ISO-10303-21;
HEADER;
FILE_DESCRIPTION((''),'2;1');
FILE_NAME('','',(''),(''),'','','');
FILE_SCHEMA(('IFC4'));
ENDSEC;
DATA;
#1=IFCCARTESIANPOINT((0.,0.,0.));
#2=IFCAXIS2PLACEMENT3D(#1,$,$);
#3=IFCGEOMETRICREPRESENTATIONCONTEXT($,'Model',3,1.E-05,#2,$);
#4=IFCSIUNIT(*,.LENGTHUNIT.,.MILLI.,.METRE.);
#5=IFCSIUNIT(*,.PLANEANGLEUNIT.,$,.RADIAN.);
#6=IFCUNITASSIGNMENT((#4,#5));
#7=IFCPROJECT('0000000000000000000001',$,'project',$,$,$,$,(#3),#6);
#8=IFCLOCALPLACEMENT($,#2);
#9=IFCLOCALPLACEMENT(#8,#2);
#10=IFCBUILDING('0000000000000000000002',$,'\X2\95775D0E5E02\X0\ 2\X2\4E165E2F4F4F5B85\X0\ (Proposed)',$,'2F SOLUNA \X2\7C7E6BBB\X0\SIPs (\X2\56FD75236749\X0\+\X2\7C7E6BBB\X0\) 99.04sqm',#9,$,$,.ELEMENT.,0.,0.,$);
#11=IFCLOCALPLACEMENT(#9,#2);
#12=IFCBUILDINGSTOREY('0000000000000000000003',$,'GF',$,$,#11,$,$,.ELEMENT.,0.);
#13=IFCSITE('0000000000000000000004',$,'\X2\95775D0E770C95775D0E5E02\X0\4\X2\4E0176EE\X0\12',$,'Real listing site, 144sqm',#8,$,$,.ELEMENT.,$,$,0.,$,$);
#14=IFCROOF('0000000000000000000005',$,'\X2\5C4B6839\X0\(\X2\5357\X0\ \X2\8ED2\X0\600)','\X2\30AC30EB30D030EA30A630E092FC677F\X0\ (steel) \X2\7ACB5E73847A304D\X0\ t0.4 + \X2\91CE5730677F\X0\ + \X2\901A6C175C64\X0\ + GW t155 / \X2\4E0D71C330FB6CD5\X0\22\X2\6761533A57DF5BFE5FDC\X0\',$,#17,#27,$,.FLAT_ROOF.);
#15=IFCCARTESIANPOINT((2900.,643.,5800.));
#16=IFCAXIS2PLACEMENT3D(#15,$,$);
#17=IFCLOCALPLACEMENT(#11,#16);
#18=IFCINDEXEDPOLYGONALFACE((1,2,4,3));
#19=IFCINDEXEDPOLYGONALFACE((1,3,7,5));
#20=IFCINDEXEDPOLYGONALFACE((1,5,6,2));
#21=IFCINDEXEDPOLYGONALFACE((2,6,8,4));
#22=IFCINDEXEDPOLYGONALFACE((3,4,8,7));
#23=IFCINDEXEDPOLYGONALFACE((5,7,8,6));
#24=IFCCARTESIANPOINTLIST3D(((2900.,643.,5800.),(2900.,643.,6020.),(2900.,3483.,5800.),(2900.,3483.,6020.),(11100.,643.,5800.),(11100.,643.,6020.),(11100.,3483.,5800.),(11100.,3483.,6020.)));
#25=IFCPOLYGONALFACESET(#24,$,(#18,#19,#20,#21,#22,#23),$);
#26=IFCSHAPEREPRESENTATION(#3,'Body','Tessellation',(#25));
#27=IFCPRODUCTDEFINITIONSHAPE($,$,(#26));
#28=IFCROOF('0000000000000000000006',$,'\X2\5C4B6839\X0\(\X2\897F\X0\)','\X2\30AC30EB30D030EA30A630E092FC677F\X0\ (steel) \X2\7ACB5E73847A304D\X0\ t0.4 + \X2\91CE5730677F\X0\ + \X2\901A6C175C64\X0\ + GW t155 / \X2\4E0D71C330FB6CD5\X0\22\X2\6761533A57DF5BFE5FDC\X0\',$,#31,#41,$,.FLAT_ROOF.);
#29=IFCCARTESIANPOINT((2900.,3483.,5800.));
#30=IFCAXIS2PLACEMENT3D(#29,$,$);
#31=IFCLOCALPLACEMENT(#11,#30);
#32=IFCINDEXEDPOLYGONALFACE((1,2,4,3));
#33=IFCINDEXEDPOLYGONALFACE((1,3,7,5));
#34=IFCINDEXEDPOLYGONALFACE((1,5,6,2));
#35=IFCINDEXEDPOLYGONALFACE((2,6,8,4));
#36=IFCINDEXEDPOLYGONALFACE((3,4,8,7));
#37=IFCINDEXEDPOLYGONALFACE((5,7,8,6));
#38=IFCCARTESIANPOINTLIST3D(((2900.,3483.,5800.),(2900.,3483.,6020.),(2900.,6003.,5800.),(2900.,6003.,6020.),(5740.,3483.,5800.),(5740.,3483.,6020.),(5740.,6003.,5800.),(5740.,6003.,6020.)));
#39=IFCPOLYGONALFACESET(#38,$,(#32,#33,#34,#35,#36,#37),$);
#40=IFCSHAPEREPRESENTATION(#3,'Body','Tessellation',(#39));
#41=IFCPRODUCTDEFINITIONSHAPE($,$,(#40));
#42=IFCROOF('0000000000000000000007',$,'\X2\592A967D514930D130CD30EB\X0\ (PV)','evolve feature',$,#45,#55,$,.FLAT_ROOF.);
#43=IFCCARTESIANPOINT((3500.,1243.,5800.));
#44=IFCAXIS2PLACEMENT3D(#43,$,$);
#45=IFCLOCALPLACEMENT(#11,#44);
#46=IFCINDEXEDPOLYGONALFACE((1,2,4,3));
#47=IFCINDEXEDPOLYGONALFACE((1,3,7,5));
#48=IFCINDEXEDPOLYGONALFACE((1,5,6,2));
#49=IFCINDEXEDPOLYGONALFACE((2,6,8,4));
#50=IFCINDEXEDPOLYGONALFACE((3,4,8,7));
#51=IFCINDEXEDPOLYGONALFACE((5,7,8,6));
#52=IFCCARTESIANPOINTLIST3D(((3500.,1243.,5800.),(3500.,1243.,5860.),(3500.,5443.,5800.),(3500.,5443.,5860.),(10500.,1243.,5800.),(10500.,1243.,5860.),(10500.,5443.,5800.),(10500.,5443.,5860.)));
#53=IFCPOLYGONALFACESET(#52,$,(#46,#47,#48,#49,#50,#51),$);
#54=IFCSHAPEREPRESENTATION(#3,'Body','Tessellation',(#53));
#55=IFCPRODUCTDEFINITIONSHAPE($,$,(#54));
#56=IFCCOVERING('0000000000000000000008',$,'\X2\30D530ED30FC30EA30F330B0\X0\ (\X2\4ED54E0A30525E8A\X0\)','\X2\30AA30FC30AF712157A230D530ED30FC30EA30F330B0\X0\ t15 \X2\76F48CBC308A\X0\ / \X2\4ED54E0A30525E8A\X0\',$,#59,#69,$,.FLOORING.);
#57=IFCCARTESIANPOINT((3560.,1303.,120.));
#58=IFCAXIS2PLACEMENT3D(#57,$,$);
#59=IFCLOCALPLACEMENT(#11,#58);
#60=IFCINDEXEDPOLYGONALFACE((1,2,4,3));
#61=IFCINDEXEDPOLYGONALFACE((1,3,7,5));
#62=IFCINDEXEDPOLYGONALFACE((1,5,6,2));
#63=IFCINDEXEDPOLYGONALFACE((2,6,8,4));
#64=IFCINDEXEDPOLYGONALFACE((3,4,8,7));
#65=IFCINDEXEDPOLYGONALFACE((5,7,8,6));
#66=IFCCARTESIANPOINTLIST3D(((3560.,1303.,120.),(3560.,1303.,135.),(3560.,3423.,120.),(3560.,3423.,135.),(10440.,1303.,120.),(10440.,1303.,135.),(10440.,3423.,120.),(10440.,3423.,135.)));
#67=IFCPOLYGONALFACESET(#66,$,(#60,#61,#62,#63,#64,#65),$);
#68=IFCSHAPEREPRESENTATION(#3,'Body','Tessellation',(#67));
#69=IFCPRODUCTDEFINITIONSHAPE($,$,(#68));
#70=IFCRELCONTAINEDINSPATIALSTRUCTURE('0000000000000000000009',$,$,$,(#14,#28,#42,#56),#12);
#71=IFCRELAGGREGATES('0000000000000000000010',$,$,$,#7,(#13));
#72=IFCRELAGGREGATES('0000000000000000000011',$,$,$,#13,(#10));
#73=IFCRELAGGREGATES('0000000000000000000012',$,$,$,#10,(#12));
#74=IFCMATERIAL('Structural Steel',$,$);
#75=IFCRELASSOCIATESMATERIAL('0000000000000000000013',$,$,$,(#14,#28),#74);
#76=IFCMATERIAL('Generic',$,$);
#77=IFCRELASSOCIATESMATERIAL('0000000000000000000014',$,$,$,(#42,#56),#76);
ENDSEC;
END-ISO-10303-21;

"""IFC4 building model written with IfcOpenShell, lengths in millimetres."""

from ifc_helpers import new_model, si_unit, frame, frame_2d, origin, place, context, project, spatial, rectangle, extrude, material, element, save


model = new_model("IFC4")

# Units and contexts
model_context = context("Model", 3, precision=1e-05, world=origin())
ifc_project = project(units=[si_unit("LENGTHUNIT", "METRE", prefix="MILLI"), si_unit("PLANEANGLEUNIT", "RADIAN")], contexts=[model_context])

# Site, building, storey
site_placement = place(None, origin())
site = spatial("IfcSite", under=ifc_project, at=site_placement, Name="長崎県長崎市4丁目12", ObjectType="Real listing site, 144sqm", CompositionType="ELEMENT", RefElevation=0.0)
building_placement = place(site_placement, origin())
building = spatial("IfcBuilding", under=site, at=building_placement, Name="長崎市 2世帯住宅 (Proposed)", ObjectType="2F SOLUNA 籾殻SIPs (国産杉+籾殻) 99.04sqm", CompositionType="ELEMENT", ElevationOfRefHeight=0.0, ElevationOfTerrain=0.0)
storey_placement = place(building_placement, origin())
storey = spatial("IfcBuildingStorey", under=building, at=storey_placement, Name="GF", CompositionType="ELEMENT", Elevation=0.0)

# Shared definitions
ifc_material_1 = material(Name="Generic")

# Roofs
ifc_material_2 = material(Name="Structural Steel")
roof_1_placement = place(storey_placement, frame((2900.0, 643.0, 5800.0)))
element("IfcRoof", 1, at=roof_1_placement, inside=storey, material=ifc_material_2, Name="屋根(南 軒600)", Description="ガルバリウム鋼板 (steel) 立平葺き t0.4 + 野地板 + 通気層 + GW t155 / 不燃・法22条区域対応", PredefinedType="FLAT_ROOF", context=model_context, shape_type="SweptSolid", body=[
    extrude(rectangle(XDim=8200.0, YDim=2840.0, at=frame_2d((4100.0, 1420.0))), frame((2900.0, 643.0, 5800.0)), (0.0, 0.0, 1.0), 220.0),
])
roof_2_placement = place(storey_placement, frame((2900.0, 3483.0, 5800.0)))
element("IfcRoof", 2, at=roof_2_placement, inside=storey, material=ifc_material_2, Name="屋根(西)", Description="ガルバリウム鋼板 (steel) 立平葺き t0.4 + 野地板 + 通気層 + GW t155 / 不燃・法22条区域対応", PredefinedType="FLAT_ROOF", context=model_context, shape_type="SweptSolid", body=[
    extrude(rectangle(XDim=2840.0, YDim=2520.0, at=frame_2d((1420.0, 1260.0))), frame((2900.0, 3483.0, 5800.0)), (0.0, 0.0, 1.0), 220.0),
])
roof_3_placement = place(storey_placement, frame((3500.0, 1243.0, 5800.0)))
element("IfcRoof", 3, at=roof_3_placement, inside=storey, material=ifc_material_1, Name="太陽光パネル (PV)", Description="evolve feature", PredefinedType="FLAT_ROOF", context=model_context, shape_type="SweptSolid", body=[
    extrude(rectangle(XDim=7000.0, YDim=4200.0, at=frame_2d((3500.0, 2100.0))), frame((3500.0, 1243.0, 5800.0)), (0.0, 0.0, 1.0), 60.0),
])

# Covering
covering_placement = place(storey_placement, frame((3560.0, 1303.0, 120.0)))
element("IfcCovering", 4, at=covering_placement, inside=storey, material=ifc_material_1, Name="フローリング (仕上げ床)", Description="オーク無垢フローリング t15 直貼り / 仕上げ床", PredefinedType="FLOORING", context=model_context, shape_type="SweptSolid", body=[
    extrude(rectangle(XDim=6880.0, YDim=2120.0, at=frame_2d((3440.0, 1060.0))), frame((3560.0, 1303.0, 120.0)), (0.0, 0.0, 1.0), 15.0),
])

save(model, "model.ifc")
